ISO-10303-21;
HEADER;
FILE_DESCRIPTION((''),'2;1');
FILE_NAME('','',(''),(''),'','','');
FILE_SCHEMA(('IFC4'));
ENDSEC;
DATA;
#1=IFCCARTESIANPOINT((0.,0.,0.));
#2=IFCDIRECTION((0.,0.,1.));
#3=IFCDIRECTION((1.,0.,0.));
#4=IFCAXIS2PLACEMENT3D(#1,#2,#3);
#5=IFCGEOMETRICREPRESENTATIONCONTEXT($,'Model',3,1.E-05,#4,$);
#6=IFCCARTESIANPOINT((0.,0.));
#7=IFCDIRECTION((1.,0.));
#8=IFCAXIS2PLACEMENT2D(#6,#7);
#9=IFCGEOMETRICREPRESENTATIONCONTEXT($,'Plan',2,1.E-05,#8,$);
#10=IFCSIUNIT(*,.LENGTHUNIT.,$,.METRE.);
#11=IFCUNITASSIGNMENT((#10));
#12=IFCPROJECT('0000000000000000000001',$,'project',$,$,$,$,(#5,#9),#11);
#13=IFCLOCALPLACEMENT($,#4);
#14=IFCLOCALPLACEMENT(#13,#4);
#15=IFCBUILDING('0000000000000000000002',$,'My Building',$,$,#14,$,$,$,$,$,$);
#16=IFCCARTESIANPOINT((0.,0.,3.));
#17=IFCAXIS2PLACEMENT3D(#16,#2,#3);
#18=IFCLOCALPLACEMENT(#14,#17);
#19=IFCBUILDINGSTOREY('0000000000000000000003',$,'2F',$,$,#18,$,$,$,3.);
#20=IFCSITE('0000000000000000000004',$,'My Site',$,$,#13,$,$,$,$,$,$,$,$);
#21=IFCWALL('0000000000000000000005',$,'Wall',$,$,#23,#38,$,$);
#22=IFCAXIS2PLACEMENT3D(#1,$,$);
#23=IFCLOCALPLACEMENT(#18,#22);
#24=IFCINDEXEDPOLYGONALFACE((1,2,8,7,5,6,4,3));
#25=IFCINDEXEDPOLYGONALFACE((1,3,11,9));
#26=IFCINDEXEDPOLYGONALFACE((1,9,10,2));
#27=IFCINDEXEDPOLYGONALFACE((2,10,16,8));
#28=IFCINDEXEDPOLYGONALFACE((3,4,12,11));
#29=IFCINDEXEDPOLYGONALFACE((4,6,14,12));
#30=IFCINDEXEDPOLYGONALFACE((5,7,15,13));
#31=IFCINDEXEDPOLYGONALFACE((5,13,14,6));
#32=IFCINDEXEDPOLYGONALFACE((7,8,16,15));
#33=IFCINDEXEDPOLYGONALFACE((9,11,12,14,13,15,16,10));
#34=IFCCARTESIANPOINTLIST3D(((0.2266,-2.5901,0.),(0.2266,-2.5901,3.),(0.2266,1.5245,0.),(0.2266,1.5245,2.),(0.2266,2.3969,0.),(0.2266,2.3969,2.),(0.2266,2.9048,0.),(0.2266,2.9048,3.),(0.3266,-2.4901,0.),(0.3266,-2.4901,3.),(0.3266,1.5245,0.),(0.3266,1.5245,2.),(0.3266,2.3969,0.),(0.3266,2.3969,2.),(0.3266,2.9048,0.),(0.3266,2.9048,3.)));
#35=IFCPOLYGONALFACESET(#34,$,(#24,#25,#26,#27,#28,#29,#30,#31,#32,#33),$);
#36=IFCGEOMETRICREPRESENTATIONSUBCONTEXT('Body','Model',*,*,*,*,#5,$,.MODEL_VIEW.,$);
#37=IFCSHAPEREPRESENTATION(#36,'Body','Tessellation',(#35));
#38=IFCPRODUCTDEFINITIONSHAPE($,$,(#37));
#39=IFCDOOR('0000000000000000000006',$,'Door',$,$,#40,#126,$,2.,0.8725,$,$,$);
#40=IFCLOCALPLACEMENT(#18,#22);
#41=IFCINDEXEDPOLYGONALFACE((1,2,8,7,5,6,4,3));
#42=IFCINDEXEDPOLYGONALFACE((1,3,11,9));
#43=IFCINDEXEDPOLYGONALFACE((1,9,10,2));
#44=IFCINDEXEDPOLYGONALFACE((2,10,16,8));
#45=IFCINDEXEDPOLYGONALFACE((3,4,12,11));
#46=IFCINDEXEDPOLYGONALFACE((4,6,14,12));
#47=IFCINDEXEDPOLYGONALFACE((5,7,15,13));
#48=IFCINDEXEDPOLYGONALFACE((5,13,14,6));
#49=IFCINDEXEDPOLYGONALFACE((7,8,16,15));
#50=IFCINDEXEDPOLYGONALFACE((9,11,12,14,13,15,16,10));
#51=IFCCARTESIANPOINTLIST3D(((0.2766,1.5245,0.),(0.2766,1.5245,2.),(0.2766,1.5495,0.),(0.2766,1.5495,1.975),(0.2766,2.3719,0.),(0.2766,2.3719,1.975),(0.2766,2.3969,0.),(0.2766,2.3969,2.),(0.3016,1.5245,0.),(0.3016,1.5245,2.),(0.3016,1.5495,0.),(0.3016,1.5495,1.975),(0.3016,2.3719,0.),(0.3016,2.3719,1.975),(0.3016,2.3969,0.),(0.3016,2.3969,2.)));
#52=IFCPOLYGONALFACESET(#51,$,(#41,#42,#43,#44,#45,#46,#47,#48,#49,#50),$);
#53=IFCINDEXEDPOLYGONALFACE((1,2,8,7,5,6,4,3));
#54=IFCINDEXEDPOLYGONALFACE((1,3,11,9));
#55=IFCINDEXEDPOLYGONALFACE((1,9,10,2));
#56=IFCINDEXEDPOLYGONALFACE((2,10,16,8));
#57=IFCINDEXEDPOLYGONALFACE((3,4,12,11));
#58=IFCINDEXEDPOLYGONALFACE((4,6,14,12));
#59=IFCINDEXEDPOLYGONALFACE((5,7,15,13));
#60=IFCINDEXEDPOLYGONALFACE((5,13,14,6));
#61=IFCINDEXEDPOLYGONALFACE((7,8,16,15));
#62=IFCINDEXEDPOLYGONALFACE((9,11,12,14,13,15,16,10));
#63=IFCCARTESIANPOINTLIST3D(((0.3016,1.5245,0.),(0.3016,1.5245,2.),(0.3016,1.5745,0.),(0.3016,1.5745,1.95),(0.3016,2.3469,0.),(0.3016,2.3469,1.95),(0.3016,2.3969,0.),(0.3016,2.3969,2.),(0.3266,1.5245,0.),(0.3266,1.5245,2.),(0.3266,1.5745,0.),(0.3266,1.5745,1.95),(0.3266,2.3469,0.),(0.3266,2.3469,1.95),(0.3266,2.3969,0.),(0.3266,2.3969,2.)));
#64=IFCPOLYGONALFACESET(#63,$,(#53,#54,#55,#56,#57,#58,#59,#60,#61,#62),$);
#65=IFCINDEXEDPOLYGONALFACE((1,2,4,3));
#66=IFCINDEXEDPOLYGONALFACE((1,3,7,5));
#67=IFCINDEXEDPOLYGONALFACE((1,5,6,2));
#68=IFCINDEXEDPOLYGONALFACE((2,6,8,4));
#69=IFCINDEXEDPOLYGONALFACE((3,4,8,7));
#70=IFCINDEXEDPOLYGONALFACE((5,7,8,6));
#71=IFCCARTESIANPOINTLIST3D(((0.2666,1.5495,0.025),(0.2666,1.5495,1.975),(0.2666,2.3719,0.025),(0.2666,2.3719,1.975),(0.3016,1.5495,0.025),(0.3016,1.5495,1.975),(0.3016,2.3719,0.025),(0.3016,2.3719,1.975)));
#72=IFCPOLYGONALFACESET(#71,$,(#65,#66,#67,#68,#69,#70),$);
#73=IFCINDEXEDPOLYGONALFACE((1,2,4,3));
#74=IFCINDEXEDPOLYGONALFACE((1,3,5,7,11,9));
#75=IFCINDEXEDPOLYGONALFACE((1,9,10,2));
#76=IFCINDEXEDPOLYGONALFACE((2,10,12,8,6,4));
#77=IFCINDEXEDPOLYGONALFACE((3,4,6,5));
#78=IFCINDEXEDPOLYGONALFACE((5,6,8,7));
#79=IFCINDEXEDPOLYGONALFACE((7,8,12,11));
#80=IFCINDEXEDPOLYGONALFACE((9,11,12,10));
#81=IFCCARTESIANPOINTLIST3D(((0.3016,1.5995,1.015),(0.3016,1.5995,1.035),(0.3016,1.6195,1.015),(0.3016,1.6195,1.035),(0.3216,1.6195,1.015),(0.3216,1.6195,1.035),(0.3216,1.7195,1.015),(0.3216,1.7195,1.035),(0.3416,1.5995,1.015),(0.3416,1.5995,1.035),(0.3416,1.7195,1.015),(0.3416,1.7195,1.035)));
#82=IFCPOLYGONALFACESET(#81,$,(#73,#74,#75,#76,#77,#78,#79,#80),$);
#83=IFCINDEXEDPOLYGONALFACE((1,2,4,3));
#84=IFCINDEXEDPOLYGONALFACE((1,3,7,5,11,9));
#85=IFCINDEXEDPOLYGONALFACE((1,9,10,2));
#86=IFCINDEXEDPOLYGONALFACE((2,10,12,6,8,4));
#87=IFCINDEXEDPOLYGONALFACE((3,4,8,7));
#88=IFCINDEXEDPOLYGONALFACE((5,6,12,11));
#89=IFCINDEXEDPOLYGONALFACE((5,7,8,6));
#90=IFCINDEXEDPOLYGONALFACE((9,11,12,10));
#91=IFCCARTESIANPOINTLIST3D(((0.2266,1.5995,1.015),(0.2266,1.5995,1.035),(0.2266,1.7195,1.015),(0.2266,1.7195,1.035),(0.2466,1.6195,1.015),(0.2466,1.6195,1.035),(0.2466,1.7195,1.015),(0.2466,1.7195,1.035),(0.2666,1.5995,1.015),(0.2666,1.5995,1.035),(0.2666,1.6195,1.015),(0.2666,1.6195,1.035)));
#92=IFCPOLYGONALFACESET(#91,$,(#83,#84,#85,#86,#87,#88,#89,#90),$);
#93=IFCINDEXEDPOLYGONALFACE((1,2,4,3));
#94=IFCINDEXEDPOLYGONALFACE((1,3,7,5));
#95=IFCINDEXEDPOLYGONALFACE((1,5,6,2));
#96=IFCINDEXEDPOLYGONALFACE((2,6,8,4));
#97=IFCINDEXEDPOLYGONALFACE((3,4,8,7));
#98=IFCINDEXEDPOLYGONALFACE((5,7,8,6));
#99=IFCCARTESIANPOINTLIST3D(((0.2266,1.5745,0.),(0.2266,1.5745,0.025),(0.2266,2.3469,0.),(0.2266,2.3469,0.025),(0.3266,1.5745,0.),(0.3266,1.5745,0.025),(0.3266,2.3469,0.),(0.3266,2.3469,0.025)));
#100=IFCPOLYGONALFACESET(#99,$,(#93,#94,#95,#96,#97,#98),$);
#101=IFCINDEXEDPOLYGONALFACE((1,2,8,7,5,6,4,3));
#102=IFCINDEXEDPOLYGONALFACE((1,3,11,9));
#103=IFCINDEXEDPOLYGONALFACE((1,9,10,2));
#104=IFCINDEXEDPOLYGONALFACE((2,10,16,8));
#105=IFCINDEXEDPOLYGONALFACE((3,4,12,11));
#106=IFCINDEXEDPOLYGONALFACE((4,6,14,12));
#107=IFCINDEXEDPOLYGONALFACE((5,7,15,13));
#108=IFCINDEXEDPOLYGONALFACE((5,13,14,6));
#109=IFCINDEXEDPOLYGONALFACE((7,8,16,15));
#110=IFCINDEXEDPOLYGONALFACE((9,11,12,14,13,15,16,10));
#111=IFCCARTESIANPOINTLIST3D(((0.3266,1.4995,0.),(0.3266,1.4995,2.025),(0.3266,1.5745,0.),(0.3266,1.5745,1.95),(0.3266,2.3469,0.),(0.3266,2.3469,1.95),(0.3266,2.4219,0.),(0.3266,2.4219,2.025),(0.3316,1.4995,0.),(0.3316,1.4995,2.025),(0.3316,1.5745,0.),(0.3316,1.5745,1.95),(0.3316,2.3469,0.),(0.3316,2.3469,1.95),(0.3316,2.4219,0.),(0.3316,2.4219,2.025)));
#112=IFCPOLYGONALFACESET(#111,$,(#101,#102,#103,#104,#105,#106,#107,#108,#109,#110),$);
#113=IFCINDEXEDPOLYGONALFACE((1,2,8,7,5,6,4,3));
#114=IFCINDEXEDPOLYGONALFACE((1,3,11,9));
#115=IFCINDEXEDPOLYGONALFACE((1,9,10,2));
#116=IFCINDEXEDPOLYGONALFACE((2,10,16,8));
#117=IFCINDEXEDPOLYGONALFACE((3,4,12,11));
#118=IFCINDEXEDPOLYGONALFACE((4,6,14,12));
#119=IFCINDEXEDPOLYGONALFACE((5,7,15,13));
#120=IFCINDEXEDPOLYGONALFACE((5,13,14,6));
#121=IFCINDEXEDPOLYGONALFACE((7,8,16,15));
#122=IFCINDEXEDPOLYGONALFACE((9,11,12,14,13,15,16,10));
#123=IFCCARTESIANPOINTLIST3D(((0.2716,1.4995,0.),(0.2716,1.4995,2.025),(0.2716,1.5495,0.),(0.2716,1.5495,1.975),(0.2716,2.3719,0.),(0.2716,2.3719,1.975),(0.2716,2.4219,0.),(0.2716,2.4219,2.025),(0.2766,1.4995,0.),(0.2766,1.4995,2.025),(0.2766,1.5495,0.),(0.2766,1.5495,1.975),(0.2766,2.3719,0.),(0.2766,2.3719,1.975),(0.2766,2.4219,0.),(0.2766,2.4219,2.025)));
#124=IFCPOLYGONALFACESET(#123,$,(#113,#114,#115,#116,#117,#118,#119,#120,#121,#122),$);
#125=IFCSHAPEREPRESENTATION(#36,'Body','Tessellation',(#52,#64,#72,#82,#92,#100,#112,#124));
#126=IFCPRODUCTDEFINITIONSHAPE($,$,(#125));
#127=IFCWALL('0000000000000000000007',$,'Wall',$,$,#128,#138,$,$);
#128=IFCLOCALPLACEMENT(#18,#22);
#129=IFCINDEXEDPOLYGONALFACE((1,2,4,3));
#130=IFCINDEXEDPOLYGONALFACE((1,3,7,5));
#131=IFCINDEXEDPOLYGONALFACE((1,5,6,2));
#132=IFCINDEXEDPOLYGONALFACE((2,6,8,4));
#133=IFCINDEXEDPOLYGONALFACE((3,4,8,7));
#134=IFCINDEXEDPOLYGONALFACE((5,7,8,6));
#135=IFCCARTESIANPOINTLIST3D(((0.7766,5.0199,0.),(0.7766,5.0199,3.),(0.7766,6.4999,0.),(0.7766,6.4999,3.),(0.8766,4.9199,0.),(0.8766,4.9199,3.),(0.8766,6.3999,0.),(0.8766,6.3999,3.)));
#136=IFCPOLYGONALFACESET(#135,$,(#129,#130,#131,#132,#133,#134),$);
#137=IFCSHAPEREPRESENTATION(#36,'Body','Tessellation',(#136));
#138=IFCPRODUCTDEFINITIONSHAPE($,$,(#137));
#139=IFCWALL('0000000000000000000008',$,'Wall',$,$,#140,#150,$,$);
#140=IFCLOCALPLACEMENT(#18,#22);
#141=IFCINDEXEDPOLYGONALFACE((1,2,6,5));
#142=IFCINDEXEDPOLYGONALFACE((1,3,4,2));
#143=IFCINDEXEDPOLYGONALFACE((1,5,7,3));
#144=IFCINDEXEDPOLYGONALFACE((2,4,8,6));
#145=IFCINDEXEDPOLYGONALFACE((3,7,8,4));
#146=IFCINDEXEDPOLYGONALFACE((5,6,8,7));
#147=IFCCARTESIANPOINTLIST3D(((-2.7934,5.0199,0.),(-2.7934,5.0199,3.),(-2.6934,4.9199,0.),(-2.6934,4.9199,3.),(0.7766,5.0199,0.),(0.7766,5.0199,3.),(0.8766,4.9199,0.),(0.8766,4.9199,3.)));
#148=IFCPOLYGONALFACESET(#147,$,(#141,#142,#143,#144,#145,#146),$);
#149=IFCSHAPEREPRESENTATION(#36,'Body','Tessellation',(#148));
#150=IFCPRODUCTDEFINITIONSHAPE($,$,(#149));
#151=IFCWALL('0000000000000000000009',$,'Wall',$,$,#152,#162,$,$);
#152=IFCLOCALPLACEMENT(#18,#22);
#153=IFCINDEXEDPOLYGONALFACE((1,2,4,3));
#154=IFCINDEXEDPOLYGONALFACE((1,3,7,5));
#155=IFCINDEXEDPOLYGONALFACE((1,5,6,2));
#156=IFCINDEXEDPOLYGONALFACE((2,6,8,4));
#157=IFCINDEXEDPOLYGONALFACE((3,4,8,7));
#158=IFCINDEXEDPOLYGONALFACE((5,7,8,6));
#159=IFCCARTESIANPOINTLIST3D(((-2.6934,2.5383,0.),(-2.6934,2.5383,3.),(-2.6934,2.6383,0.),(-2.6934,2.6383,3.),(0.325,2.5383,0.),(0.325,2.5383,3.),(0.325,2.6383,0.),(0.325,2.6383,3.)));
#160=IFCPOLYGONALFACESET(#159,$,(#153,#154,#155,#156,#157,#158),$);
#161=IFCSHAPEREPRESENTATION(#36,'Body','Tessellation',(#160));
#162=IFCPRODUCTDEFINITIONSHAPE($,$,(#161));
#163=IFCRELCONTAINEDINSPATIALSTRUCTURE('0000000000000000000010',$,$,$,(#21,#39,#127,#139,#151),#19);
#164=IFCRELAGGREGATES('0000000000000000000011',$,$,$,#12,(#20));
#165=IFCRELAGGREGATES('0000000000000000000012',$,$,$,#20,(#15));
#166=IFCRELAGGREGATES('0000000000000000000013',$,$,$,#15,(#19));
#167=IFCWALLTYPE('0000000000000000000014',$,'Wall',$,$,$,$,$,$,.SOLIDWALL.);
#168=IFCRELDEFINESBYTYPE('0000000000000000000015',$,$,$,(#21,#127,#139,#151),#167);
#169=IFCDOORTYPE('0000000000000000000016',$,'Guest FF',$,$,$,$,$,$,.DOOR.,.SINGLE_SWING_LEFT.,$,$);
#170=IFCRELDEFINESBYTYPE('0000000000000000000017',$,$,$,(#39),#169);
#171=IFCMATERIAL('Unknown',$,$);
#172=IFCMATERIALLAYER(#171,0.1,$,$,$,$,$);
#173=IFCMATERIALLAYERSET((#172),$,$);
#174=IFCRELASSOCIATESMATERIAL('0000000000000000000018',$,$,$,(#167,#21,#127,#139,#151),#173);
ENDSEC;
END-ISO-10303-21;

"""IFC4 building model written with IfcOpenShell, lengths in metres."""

from ifc_helpers import new_model, entity, si_unit, frame, origin_with_axes, origin_2d_with_axis, place, context, subcontext, project, spatial, line, indexed_curve, outline, extrude, shape, source, transform, mapped, material, layer, layer_set, layer_usage, type_object, type_shapes, element, fill, save


model = new_model("IFC4")

# Units and contexts
model_context = context("Model", 3, precision=1e-05, world=origin_with_axes())
plan_context = context("Plan", 2, precision=1e-05, world=origin_2d_with_axis())
body_context_1 = subcontext(model_context, "Body", "Model", "MODEL_VIEW")
body_context_2 = subcontext(plan_context, "Body", "Plan", "PLAN_VIEW")
ifc_project = project(units=[si_unit("LENGTHUNIT", "METRE")], contexts=[model_context, plan_context])

# Site, building, storey
site_placement = place(None, origin_with_axes())
site = spatial("IfcSite", under=ifc_project, at=site_placement, Name="My Site")
building_placement = place(site_placement, origin_with_axes())
building = spatial("IfcBuilding", under=site, at=building_placement, Name="My Building")
storey_placement = place(building_placement, frame((0.0, 0.0, 3.0), z_axis=(0.0, 0.0, 1.0), x_axis=(1.0, 0.0, 0.0)))
storey = spatial("IfcBuildingStorey", under=building, at=storey_placement, Name="2F", Elevation=3.0)

# Shared definitions
ifc_material = material(Name="Unknown")

# Shared definitions
ifc_layer_1 = layer(ifc_material, 0.1)
ifc_layer_set_1 = layer_set([ifc_layer_1])
wall_type = type_object("IfcWallType", Name="Wall", PredefinedType="SOLIDWALL", material=ifc_layer_set_1)

# Wall, opening, door
ifc_layer_usage_1 = layer_usage(ifc_layer_set_1, "AXIS2", "POSITIVE", 0.0)
wall_1_placement = place(storey_placement, frame((0.2266, 2.9048, 0.0), z_axis=(0.0, 0.0, 1.0), x_axis=(0.0, -1.0, 0.0)))
wall_1 = element("IfcWall", 1, at=wall_1_placement, inside=storey, type_object=wall_type, material=ifc_layer_usage_1, Name="Wall", context=body_context_1, shape_type="SweptSolid", body=[
    extrude(outline(indexed_curve([(0.0, 0.0), (0.0, 0.1), (5.3949, 0.1), (5.4949, 0.0)], segments=[line(1, 2, 3, 4, 1)])), origin_with_axes(), (0.0, 0.0, 1.0), 3.0),
])
shared_shape_1 = source(origin_with_axes(), body_context_1, "Body", "SweptSolid", [
    extrude(outline(indexed_curve([(0.0, 0.0), (0.8725, 0.0), (0.8725, 2.0), (0.0, 2.0)], segments=[line(1, 2, 3, 4, 1)])), frame((0.0, -0.6, 0.0), z_axis=(0.0, -1.0, 0.0), x_axis=(1.0, 0.0, 0.0)), (0.0, 0.0, -1.0), 1.2),
])
opening_1_placement = place(wall_1_placement, frame((1.3803, 0.1, 0.0), z_axis=(0.0, 0.0, 1.0), x_axis=(-1.0, 0.0, 0.0)))
opening_1 = element("IfcOpeningElement", 2, at=opening_1_placement, cuts=wall_1, PredefinedType="OPENING", context=body_context_1, shape_type="MappedRepresentation", body=[
    mapped(shared_shape_1, transform((0.0, 0.0, 0.0), x_axis=(1.0, 0.0, 0.0), y_axis=(0.0, 1.0, 0.0), z_axis=(0.0, 0.0, 1.0), scale=1.0)),
])
door_type_1 = type_object("IfcDoorType", Name="Guest FF", OperationType="SINGLE_SWING_LEFT", PredefinedType="DOOR")
shared_shape_2 = source(origin_with_axes(), body_context_1, "Body", "SweptSolid", [
    extrude(outline(indexed_curve([(0.0, 0.0), (0.0, 2.0), (0.8725, 2.0), (0.8725, 0.0), (0.8475, 0.0), (0.8475, 1.975), (0.025, 1.975), (0.025, 0.0)], segments=[line(1, 2, 3, 4, 5, 6, 7, 8, 1)])), frame((0.0, 0.025, 0.0), z_axis=(0.0, -1.0, 0.0), x_axis=(1.0, 0.0, 0.0)), (0.0, 0.0, -1.0), 0.025),
    extrude(outline(indexed_curve([(0.0, 0.0), (0.0, 2.0), (0.8725, 2.0), (0.8725, 0.0), (0.8225, 0.0), (0.8225, 1.95), (0.05, 1.95), (0.05, 0.0)], segments=[line(1, 2, 3, 4, 5, 6, 7, 8, 1)])), frame((0.0, 0.0, 0.0), z_axis=(0.0, -1.0, 0.0), x_axis=(1.0, 0.0, 0.0)), (0.0, 0.0, -1.0), 0.025),
    extrude(outline(indexed_curve([(0.0, 0.0), (0.8225, 0.0), (0.8225, 0.035), (0.0, 0.035)], segments=[line(1, 2, 3, 4, 1)])), frame((0.025, 0.025, 0.025), z_axis=(0.0, 0.0, 1.0), x_axis=(1.0, 0.0, 0.0)), (0.0, 0.0, 1.0), 1.95),
    extrude(outline(indexed_curve([(0.0, 0.0), (0.0, -0.04), (0.12, -0.04), (0.12, -0.02), (0.02, -0.02), (0.02, 0.0)], segments=[line(1, 2, 3, 4, 5, 6, 1)])), frame((0.075, 0.025, 1.015), z_axis=(0.0, 0.0, 1.0), x_axis=(1.0, 0.0, 0.0)), (0.0, 0.0, 1.0), 0.02),
    extrude(outline(indexed_curve([(0.0, 0.0), (0.0, 0.04), (0.12, 0.04), (0.12, 0.02), (0.02, 0.02), (0.02, 0.0)], segments=[line(1, 2, 3, 4, 5, 6, 1)])), frame((0.075, 0.06, 1.015), z_axis=(0.0, 0.0, 1.0), x_axis=(1.0, 0.0, 0.0)), (0.0, 0.0, 1.0), 0.02),
    extrude(outline(indexed_curve([(0.0, 0.0), (0.7725, 0.0), (0.7725, 0.1), (0.0, 0.1)], segments=[line(1, 2, 3, 4, 1)])), frame((0.05, 0.0, 0.0), z_axis=(0.0, 0.0, 1.0), x_axis=(1.0, 0.0, 0.0)), (0.0, 0.0, 1.0), 0.025),
    extrude(outline(indexed_curve([(0.0, 0.0), (0.0, 2.025), (0.9225, 2.025), (0.9225, 0.0), (0.8475, 0.0), (0.8475, 1.95), (0.075, 1.95), (0.075, 0.0)], segments=[line(1, 2, 3, 4, 5, 6, 7, 8, 1)])), frame((-0.025, -0.005, 0.0), z_axis=(0.0, -1.0, 0.0), x_axis=(1.0, 0.0, 0.0)), (0.0, 0.0, -1.0), 0.005),
    extrude(outline(indexed_curve([(0.0, 0.0), (0.0, 2.025), (0.9225, 2.025), (0.9225, 0.0), (0.8725, 0.0), (0.8725, 1.975), (0.05, 1.975), (0.05, 0.0)], segments=[line(1, 2, 3, 4, 5, 6, 7, 8, 1)])), frame((-0.025, 0.05, 0.0), z_axis=(0.0, -1.0, 0.0), x_axis=(1.0, 0.0, 0.0)), (0.0, 0.0, -1.0), 0.005),
])
shared_shape_3 = source(origin_with_axes(), body_context_2, "Body", "Curve2D", [
    entity("IfcIndexedPolyCurve", entity("IfcCartesianPointList2D", [[0.0, 0.0], [0.0, 0.05], [0.025, 0.05], [0.025, 0.025], [0.05, 0.025], [0.05, 0.0]]), [entity("IfcLineIndex", [1, 2, 3, 4, 5, 6, 1])]),
    entity("IfcIndexedPolyCurve", entity("IfcCartesianPointList2D", [[0.8725, 0.0], [0.8725, 0.05], [0.8475, 0.05], [0.8475, 0.025], [0.8225, 0.025], [0.8225, 0.0]]), [entity("IfcLineIndex", [1, 2, 3, 4, 5, 6, 1])]),
    entity("IfcTrimmedCurve", entity("IfcEllipse", entity("IfcAxis2Placement2D", entity("IfcCartesianPoint", [0.8125, 0.05]), entity("IfcDirection", [1.0, 0.0])), 0.7875, 0.8225), [entity("IfcCartesianPoint", [0.8125, 0.8725])], [entity("IfcCartesianPoint", [0.025, 0.05])], True, "CARTESIAN"),
    entity("IfcIndexedPolyCurve", entity("IfcCartesianPointList2D", [[0.8475, 0.05], [0.8125, 0.05], [0.8125, 0.8725], [0.8475, 0.8725]]), [entity("IfcLineIndex", [1, 2, 3, 4, 1])]),
])
type_shapes(door_type_1, [shared_shape_2, shared_shape_3])
door_1_placement = place(opening_1_placement, frame((0.0, 0.0, 0.0), z_axis=(0.0, 0.0, 1.0), x_axis=(1.0, 0.0, 0.0)))
door_1 = element("IfcDoor", 3, at=door_1_placement, inside=storey, type_object=door_type_1, Name="Door", OverallHeight=2.0, OverallWidth=0.8725, shapes=[
    shape(body_context_1, "Body", "MappedRepresentation", [mapped(shared_shape_2, transform((0.0, 0.0, 0.0), x_axis=(1.0, 0.0, 0.0), y_axis=(0.0, 1.0, 0.0), z_axis=(0.0, 0.0, 1.0), scale=1.0))]),
    shape(body_context_2, "Body", "MappedRepresentation", [mapped(shared_shape_3, transform((0.0, 0.0, 0.0), x_axis=(1.0, 0.0, 0.0), y_axis=(0.0, 1.0, 0.0), z_axis=(0.0, 0.0, 1.0), scale=1.0))]),
])
fill(opening_1, door_1)

# Walls
ifc_layer_usage_2 = layer_usage(ifc_layer_set_1, "AXIS2", "POSITIVE", 0.0)
wall_2_placement = place(storey_placement, frame((0.7766, 6.4999, 0.0), z_axis=(0.0, 0.0, 1.0), x_axis=(0.0, -1.0, 0.0)))
element("IfcWall", 4, at=wall_2_placement, inside=storey, type_object=wall_type, material=ifc_layer_usage_2, Name="Wall", context=body_context_1, shape_type="SweptSolid", body=[
    extrude(outline(indexed_curve([(0.0, 0.0), (0.1, 0.1), (1.58, 0.1), (1.48, 0.0)], segments=[line(1, 2, 3, 4, 1)])), origin_with_axes(), (0.0, 0.0, 1.0), 3.0),
])
ifc_layer_usage_3 = layer_usage(ifc_layer_set_1, "AXIS2", "POSITIVE", 0.0)
wall_3_placement = place(storey_placement, frame((0.7766, 5.0199, 0.0), z_axis=(0.0, 0.0, 1.0), x_axis=(-1.0, 0.0, 0.0)))
element("IfcWall", 5, at=wall_3_placement, inside=storey, type_object=wall_type, material=ifc_layer_usage_3, Name="Wall", context=body_context_1, shape_type="SweptSolid", body=[
    extrude(outline(indexed_curve([(0.0, 0.0), (-0.1, 0.1), (3.47, 0.1), (3.57, 0.0)], segments=[line(1, 2, 3, 4, 1)])), origin_with_axes(), (0.0, 0.0, 1.0), 3.0),
])
ifc_layer_usage_4 = layer_usage(ifc_layer_set_1, "AXIS2", "POSITIVE", 0.0)
wall_4_placement = place(storey_placement, frame((0.325, 2.6383, 0.0), z_axis=(0.0, 0.0, 1.0), x_axis=(-1.0, 0.0, 0.0)))
element("IfcWall", 6, at=wall_4_placement, inside=storey, type_object=wall_type, material=ifc_layer_usage_4, Name="Wall", context=body_context_1, shape_type="SweptSolid", body=[
    extrude(outline(indexed_curve([(0.0, 0.0), (0.0, 0.1), (3.0184, 0.1), (3.0184, 0.0)], segments=[line(1, 2, 3, 4, 1)])), origin_with_axes(), (0.0, 0.0, 1.0), 3.0),
])

save(model, "model.ifc")
